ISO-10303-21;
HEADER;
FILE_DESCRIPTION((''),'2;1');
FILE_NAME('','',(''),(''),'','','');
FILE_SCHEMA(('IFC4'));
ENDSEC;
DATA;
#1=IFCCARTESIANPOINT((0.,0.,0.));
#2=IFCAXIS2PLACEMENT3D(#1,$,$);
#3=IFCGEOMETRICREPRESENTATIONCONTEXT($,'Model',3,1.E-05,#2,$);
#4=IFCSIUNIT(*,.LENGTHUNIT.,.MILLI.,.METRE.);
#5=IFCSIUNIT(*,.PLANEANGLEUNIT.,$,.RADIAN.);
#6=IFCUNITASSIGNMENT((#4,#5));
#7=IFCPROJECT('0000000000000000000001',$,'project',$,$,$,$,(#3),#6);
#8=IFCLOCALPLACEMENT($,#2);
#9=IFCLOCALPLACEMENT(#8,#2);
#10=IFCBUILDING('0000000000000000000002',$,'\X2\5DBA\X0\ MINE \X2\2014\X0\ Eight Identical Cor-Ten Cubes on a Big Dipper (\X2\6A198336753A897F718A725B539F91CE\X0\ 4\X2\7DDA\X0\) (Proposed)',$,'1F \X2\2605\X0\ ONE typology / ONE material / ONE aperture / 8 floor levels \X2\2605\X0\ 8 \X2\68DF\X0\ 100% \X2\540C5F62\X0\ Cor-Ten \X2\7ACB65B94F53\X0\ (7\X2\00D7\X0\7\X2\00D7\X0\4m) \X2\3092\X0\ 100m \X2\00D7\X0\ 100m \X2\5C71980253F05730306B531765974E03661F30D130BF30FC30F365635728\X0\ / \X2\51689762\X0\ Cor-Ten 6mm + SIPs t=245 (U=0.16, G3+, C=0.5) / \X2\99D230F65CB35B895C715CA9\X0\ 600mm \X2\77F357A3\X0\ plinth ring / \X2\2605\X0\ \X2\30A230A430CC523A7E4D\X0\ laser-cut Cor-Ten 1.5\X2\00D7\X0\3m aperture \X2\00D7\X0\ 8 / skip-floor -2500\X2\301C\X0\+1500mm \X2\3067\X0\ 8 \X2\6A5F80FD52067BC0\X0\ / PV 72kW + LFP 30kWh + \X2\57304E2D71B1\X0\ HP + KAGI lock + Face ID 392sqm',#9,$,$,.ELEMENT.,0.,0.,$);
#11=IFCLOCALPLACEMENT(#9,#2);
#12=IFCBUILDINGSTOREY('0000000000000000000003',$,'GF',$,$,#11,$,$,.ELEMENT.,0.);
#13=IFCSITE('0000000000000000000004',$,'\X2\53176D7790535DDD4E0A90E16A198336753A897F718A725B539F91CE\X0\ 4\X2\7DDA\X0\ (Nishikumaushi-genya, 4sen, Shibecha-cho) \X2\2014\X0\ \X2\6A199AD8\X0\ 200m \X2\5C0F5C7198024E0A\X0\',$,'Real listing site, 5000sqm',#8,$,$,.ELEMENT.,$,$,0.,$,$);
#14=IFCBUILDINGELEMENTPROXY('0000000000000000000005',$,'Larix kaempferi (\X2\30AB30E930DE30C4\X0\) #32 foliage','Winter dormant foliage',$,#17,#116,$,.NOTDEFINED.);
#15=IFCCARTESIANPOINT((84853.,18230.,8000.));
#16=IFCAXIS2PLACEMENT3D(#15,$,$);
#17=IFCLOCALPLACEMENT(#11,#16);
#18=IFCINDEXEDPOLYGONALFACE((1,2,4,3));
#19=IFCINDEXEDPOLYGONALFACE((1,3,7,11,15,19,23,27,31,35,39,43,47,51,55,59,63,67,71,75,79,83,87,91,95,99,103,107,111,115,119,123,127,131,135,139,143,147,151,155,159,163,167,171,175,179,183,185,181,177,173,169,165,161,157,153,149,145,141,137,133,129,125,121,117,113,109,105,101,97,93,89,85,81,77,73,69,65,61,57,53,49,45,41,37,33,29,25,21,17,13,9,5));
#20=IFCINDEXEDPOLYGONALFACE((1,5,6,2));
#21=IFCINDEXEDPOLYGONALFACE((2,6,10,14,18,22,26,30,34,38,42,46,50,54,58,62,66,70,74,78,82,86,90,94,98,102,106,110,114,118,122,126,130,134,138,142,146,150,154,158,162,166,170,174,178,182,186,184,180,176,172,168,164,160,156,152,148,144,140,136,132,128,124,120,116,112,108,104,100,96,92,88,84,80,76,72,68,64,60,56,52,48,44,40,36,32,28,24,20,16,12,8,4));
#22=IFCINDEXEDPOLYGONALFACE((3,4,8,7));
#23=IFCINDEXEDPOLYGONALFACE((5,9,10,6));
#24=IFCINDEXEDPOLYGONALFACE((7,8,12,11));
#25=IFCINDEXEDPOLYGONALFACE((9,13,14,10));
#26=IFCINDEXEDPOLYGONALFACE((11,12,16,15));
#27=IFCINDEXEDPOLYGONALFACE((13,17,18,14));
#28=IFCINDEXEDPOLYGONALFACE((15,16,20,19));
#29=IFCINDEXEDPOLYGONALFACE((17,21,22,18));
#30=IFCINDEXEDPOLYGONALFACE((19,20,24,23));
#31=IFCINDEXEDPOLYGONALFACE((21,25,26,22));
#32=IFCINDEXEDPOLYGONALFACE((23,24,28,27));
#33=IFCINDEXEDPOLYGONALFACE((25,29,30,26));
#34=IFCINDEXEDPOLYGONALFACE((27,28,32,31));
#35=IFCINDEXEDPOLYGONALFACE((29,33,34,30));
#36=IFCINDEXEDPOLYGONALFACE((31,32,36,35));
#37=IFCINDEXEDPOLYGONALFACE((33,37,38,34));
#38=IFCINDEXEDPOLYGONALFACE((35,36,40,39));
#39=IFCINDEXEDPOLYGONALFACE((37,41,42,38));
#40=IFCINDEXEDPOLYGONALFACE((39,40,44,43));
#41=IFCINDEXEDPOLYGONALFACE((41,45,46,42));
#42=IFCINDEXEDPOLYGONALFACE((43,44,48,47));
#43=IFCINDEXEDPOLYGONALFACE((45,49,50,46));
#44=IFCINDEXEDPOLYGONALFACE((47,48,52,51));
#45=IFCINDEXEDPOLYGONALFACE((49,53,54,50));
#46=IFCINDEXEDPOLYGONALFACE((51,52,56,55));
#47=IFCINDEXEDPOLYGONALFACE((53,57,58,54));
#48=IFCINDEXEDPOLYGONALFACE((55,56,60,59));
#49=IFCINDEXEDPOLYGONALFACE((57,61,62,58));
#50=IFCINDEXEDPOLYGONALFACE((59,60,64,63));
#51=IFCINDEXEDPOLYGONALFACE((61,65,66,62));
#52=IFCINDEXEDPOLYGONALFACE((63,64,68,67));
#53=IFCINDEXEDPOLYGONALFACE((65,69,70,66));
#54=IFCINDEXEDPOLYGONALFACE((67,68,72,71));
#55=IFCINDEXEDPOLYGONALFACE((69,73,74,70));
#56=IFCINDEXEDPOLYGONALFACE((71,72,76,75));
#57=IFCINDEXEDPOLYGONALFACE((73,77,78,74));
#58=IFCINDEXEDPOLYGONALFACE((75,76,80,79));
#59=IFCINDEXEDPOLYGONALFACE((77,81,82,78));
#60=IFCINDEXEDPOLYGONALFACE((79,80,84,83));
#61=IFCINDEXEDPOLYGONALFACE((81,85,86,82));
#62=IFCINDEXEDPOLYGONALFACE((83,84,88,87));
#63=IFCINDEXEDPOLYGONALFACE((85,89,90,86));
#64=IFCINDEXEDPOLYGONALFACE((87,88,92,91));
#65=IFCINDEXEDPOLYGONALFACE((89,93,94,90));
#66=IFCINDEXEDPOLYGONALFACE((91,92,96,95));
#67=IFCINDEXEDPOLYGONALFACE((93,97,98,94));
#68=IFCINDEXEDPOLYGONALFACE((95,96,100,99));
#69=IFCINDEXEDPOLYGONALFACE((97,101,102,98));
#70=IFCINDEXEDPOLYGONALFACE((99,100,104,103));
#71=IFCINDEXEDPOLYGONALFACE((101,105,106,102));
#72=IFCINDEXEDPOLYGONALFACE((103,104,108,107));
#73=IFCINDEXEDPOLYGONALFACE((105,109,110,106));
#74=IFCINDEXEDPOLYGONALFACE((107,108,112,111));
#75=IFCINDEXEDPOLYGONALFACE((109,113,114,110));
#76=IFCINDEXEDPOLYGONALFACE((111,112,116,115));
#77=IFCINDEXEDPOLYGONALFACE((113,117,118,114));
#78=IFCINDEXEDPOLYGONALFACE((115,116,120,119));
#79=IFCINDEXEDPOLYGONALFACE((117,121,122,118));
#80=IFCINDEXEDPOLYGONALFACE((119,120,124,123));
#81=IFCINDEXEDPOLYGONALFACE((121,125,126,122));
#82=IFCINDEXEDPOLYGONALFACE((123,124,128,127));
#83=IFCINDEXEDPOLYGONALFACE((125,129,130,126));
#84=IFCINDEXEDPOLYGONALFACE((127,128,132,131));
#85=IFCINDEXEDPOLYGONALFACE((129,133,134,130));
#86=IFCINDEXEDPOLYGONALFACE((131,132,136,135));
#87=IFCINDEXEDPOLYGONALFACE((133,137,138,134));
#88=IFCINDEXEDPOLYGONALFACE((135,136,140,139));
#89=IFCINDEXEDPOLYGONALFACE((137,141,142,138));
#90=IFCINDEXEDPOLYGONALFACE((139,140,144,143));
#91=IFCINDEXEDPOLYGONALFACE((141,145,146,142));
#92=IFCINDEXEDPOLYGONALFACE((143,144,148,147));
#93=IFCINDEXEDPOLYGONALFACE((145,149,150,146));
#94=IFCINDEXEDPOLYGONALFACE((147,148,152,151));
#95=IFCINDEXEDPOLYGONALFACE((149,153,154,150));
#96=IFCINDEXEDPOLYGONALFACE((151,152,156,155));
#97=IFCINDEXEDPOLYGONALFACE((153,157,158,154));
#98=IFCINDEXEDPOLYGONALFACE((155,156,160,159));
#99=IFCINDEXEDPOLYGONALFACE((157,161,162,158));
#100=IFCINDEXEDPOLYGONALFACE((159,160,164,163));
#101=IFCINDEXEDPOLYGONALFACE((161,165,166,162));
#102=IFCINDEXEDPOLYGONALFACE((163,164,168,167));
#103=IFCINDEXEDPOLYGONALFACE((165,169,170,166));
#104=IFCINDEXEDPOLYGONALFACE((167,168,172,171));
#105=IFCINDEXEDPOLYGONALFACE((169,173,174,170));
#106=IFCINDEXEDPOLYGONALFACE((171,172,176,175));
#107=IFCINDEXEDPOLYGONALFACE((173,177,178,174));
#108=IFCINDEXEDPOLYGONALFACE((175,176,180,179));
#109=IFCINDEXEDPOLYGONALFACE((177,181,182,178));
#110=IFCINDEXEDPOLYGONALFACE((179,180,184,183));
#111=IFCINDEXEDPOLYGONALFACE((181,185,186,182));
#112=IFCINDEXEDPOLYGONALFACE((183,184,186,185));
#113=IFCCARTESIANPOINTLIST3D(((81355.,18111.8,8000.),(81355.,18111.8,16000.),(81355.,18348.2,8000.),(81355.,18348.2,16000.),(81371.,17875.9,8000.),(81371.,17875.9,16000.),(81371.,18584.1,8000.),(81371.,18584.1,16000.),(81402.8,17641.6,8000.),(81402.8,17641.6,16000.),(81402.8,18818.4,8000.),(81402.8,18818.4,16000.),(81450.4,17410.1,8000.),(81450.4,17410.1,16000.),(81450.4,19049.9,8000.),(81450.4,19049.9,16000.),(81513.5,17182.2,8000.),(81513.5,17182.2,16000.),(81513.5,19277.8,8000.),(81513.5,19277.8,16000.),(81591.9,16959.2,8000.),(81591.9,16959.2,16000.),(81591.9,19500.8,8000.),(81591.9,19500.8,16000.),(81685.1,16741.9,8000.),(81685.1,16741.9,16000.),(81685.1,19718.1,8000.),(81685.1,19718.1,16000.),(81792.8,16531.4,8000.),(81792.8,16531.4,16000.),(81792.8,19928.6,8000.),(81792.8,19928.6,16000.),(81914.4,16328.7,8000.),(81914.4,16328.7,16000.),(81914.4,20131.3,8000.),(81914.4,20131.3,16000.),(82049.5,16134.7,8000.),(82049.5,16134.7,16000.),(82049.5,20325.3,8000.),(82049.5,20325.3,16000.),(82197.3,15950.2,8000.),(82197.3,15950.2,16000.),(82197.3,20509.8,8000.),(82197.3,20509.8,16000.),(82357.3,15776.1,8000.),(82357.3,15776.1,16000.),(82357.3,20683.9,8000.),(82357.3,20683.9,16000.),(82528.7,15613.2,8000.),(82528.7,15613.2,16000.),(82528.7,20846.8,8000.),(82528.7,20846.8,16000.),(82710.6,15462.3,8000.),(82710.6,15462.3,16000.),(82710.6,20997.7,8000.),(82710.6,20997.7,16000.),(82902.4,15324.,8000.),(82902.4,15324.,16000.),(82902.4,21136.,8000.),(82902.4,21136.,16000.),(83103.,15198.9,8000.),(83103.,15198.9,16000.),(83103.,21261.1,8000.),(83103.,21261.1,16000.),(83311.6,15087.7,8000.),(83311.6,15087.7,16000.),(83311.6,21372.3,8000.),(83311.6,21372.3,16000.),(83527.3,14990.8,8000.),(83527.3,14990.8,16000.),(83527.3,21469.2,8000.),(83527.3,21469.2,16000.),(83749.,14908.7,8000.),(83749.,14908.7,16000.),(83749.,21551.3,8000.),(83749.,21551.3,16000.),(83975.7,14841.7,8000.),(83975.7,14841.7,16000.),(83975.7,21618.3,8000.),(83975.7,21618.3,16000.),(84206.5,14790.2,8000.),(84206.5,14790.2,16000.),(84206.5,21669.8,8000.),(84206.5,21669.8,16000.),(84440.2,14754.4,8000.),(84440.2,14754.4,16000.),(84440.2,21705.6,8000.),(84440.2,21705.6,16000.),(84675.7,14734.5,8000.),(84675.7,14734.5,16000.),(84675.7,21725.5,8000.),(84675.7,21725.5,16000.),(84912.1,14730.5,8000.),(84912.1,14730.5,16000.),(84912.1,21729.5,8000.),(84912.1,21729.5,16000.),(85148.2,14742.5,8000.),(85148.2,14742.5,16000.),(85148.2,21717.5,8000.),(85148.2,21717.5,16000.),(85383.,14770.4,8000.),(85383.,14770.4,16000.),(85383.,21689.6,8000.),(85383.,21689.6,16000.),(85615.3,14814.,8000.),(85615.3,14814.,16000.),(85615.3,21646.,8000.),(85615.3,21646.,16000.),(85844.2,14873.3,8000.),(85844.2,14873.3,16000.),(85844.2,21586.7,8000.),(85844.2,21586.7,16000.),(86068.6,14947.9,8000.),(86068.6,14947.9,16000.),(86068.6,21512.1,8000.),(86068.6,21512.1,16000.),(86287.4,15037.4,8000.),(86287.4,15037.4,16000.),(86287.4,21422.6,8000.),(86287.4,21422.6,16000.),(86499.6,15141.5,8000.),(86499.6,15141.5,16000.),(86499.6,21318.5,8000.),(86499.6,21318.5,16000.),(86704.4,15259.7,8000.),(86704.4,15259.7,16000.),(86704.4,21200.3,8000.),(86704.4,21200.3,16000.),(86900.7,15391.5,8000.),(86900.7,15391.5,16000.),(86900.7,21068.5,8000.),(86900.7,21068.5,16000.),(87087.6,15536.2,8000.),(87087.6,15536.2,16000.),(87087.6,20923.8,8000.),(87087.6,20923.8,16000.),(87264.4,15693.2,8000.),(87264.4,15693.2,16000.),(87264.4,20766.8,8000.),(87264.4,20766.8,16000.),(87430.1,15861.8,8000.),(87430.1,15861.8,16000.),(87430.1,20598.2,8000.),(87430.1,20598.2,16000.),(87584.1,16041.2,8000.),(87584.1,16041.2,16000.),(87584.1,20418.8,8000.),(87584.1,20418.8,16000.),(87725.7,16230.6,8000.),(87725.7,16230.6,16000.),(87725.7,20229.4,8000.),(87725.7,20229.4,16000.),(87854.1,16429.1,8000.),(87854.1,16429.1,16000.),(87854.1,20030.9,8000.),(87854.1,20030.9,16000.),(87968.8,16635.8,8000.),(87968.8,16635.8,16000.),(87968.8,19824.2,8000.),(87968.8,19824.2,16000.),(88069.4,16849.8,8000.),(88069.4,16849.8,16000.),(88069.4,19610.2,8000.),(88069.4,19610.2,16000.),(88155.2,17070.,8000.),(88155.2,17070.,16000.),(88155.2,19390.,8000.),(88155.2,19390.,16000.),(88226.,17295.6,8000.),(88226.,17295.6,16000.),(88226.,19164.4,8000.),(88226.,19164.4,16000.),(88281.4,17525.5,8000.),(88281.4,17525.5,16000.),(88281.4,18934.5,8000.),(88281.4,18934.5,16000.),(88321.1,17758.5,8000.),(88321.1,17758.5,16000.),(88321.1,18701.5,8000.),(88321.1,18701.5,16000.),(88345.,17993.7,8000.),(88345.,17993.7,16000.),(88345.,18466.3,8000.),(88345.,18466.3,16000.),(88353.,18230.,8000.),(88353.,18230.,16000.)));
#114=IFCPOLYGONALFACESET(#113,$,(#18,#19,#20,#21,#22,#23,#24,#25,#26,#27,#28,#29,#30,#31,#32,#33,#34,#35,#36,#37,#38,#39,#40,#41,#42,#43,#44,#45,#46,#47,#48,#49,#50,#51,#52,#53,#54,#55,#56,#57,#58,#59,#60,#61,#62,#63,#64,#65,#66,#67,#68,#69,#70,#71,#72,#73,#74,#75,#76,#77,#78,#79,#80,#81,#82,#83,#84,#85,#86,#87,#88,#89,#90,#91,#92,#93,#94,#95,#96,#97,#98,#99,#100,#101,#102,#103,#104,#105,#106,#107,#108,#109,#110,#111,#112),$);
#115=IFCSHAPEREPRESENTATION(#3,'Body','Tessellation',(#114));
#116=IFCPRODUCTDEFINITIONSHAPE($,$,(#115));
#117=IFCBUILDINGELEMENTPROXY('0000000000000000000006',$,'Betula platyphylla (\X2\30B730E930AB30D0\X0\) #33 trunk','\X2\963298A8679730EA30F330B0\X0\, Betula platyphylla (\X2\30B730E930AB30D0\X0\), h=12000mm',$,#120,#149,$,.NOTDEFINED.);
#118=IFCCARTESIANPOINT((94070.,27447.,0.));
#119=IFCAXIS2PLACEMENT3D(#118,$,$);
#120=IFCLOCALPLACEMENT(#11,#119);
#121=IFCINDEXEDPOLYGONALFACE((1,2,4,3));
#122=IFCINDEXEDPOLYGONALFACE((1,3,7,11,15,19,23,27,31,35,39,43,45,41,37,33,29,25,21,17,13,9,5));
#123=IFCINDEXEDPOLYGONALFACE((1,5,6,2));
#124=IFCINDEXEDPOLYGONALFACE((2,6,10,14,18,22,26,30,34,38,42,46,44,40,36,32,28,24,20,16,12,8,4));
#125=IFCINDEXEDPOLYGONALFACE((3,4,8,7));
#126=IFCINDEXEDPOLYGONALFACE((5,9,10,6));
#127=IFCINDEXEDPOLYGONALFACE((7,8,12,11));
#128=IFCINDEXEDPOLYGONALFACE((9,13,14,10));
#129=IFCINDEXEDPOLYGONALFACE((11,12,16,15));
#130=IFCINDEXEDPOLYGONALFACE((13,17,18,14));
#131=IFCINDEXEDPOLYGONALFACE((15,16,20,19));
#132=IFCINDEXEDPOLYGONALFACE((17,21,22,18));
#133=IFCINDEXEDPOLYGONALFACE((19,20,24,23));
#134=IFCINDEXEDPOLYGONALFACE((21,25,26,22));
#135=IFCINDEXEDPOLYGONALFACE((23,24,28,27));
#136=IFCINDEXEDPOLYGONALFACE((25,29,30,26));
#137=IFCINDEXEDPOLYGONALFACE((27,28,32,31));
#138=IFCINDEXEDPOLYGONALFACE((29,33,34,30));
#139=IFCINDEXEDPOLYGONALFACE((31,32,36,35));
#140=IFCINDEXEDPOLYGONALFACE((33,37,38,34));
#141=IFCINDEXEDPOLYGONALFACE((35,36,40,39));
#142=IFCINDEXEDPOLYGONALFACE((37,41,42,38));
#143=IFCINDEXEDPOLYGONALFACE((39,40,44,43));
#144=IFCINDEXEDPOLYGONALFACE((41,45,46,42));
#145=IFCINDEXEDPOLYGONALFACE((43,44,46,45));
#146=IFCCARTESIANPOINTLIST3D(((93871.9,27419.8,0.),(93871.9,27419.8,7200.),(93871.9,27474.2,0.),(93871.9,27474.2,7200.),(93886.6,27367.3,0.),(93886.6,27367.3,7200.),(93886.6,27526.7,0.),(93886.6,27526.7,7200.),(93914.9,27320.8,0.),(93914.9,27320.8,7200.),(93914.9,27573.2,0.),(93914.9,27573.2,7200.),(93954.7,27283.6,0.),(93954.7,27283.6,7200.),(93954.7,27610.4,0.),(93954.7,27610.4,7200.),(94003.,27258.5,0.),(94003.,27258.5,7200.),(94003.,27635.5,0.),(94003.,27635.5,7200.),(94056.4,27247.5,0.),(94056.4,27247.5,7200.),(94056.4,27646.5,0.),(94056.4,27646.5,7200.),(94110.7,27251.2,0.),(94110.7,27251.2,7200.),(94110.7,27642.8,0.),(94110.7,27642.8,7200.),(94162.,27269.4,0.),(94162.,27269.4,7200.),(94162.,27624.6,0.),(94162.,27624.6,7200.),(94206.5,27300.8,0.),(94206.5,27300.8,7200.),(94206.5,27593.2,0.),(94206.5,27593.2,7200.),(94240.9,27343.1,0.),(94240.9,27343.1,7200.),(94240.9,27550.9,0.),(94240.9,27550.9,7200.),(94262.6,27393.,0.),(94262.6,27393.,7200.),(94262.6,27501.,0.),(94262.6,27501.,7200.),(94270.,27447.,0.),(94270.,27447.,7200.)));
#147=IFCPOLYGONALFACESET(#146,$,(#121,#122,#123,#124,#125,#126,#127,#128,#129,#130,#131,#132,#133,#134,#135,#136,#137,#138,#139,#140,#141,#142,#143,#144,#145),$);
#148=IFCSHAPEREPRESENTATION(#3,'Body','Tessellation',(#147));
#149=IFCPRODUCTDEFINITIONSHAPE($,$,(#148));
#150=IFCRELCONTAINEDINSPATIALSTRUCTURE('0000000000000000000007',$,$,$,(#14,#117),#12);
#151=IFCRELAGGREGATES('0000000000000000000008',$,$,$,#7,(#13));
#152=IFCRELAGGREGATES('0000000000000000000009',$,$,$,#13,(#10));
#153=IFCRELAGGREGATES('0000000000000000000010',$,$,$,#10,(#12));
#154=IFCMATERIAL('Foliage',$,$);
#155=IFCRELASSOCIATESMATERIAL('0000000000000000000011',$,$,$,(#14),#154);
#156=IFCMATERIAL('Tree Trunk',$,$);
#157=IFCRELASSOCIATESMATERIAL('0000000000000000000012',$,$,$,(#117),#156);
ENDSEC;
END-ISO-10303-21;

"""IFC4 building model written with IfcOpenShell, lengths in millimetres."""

from ifc_helpers import new_model, si_unit, frame, origin, origin_2d, place, context, project, spatial, circle, extrude, material, element, save


model = new_model("IFC4")

# Units and contexts
model_context = context("Model", 3, precision=1e-05, world=origin())
ifc_project = project(units=[si_unit("LENGTHUNIT", "METRE", prefix="MILLI"), si_unit("PLANEANGLEUNIT", "RADIAN")], contexts=[model_context])

# Site, building, storey
site_placement = place(None, origin())
site = spatial("IfcSite", under=ifc_project, at=site_placement, Name="北海道川上郡標茶町西熊牛原野 4線 (Nishikumaushi-genya, 4sen, Shibecha-cho) — 標高 200m 小山頂上", ObjectType="Real listing site, 5000sqm", CompositionType="ELEMENT", RefElevation=0.0)
building_placement = place(site_placement, origin())
building = spatial("IfcBuilding", under=site, at=building_placement, Name="嶺 MINE — Eight Identical Cor-Ten Cubes on a Big Dipper (標茶町西熊牛原野 4線) (Proposed)", ObjectType="1F ★ ONE typology / ONE material / ONE aperture / 8 floor levels ★ 8 棟 100% 同形 Cor-Ten 立方体 (7×7×4m) を 100m × 100m 山頂台地に北斗七星パターン散在 / 全面 Cor-Ten 6mm + SIPs t=245 (U=0.16, G3+, C=0.5) / 駒ヶ岳安山岩 600mm 石垣 plinth ring / ★ アイヌ刺繍 laser-cut Cor-Ten 1.5×3m aperture × 8 / skip-floor -2500〜+1500mm で 8 機能分節 / PV 72kW + LFP 30kWh + 地中熱 HP + KAGI lock + Face ID 392sqm", CompositionType="ELEMENT", ElevationOfRefHeight=0.0, ElevationOfTerrain=0.0)
storey_placement = place(building_placement, origin())
storey = spatial("IfcBuildingStorey", under=building, at=storey_placement, Name="GF", CompositionType="ELEMENT", Elevation=0.0)

# Building element proxies
ifc_material_1 = material(Name="Tree Trunk")
ifc_material_2 = material(Name="Foliage")
proxy_1_placement = place(storey_placement, frame((84853.0, 18230.0, 8000.0)))
element("IfcBuildingElementProxy", 1, at=proxy_1_placement, inside=storey, material=ifc_material_2, Name="Larix kaempferi (カラマツ) #32 foliage", Description="Winter dormant foliage", PredefinedType="NOTDEFINED", context=model_context, shape_type="SweptSolid", body=[
    extrude(circle(Radius=3500.0, at=origin_2d()), frame((84853.0, 18230.0, 8000.0)), (0.0, 0.0, 1.0), 8000.0),
])
proxy_2_placement = place(storey_placement, frame((94070.0, 27447.0, 0.0)))
element("IfcBuildingElementProxy", 2, at=proxy_2_placement, inside=storey, material=ifc_material_1, Name="Betula platyphylla (シラカバ) #33 trunk", Description="防風林リング, Betula platyphylla (シラカバ), h=12000mm", PredefinedType="NOTDEFINED", context=model_context, shape_type="SweptSolid", body=[
    extrude(circle(Radius=200.0, at=origin_2d()), frame((94070.0, 27447.0, 0.0)), (0.0, 0.0, 1.0), 7200.0),
])

save(model, "model.ifc")
